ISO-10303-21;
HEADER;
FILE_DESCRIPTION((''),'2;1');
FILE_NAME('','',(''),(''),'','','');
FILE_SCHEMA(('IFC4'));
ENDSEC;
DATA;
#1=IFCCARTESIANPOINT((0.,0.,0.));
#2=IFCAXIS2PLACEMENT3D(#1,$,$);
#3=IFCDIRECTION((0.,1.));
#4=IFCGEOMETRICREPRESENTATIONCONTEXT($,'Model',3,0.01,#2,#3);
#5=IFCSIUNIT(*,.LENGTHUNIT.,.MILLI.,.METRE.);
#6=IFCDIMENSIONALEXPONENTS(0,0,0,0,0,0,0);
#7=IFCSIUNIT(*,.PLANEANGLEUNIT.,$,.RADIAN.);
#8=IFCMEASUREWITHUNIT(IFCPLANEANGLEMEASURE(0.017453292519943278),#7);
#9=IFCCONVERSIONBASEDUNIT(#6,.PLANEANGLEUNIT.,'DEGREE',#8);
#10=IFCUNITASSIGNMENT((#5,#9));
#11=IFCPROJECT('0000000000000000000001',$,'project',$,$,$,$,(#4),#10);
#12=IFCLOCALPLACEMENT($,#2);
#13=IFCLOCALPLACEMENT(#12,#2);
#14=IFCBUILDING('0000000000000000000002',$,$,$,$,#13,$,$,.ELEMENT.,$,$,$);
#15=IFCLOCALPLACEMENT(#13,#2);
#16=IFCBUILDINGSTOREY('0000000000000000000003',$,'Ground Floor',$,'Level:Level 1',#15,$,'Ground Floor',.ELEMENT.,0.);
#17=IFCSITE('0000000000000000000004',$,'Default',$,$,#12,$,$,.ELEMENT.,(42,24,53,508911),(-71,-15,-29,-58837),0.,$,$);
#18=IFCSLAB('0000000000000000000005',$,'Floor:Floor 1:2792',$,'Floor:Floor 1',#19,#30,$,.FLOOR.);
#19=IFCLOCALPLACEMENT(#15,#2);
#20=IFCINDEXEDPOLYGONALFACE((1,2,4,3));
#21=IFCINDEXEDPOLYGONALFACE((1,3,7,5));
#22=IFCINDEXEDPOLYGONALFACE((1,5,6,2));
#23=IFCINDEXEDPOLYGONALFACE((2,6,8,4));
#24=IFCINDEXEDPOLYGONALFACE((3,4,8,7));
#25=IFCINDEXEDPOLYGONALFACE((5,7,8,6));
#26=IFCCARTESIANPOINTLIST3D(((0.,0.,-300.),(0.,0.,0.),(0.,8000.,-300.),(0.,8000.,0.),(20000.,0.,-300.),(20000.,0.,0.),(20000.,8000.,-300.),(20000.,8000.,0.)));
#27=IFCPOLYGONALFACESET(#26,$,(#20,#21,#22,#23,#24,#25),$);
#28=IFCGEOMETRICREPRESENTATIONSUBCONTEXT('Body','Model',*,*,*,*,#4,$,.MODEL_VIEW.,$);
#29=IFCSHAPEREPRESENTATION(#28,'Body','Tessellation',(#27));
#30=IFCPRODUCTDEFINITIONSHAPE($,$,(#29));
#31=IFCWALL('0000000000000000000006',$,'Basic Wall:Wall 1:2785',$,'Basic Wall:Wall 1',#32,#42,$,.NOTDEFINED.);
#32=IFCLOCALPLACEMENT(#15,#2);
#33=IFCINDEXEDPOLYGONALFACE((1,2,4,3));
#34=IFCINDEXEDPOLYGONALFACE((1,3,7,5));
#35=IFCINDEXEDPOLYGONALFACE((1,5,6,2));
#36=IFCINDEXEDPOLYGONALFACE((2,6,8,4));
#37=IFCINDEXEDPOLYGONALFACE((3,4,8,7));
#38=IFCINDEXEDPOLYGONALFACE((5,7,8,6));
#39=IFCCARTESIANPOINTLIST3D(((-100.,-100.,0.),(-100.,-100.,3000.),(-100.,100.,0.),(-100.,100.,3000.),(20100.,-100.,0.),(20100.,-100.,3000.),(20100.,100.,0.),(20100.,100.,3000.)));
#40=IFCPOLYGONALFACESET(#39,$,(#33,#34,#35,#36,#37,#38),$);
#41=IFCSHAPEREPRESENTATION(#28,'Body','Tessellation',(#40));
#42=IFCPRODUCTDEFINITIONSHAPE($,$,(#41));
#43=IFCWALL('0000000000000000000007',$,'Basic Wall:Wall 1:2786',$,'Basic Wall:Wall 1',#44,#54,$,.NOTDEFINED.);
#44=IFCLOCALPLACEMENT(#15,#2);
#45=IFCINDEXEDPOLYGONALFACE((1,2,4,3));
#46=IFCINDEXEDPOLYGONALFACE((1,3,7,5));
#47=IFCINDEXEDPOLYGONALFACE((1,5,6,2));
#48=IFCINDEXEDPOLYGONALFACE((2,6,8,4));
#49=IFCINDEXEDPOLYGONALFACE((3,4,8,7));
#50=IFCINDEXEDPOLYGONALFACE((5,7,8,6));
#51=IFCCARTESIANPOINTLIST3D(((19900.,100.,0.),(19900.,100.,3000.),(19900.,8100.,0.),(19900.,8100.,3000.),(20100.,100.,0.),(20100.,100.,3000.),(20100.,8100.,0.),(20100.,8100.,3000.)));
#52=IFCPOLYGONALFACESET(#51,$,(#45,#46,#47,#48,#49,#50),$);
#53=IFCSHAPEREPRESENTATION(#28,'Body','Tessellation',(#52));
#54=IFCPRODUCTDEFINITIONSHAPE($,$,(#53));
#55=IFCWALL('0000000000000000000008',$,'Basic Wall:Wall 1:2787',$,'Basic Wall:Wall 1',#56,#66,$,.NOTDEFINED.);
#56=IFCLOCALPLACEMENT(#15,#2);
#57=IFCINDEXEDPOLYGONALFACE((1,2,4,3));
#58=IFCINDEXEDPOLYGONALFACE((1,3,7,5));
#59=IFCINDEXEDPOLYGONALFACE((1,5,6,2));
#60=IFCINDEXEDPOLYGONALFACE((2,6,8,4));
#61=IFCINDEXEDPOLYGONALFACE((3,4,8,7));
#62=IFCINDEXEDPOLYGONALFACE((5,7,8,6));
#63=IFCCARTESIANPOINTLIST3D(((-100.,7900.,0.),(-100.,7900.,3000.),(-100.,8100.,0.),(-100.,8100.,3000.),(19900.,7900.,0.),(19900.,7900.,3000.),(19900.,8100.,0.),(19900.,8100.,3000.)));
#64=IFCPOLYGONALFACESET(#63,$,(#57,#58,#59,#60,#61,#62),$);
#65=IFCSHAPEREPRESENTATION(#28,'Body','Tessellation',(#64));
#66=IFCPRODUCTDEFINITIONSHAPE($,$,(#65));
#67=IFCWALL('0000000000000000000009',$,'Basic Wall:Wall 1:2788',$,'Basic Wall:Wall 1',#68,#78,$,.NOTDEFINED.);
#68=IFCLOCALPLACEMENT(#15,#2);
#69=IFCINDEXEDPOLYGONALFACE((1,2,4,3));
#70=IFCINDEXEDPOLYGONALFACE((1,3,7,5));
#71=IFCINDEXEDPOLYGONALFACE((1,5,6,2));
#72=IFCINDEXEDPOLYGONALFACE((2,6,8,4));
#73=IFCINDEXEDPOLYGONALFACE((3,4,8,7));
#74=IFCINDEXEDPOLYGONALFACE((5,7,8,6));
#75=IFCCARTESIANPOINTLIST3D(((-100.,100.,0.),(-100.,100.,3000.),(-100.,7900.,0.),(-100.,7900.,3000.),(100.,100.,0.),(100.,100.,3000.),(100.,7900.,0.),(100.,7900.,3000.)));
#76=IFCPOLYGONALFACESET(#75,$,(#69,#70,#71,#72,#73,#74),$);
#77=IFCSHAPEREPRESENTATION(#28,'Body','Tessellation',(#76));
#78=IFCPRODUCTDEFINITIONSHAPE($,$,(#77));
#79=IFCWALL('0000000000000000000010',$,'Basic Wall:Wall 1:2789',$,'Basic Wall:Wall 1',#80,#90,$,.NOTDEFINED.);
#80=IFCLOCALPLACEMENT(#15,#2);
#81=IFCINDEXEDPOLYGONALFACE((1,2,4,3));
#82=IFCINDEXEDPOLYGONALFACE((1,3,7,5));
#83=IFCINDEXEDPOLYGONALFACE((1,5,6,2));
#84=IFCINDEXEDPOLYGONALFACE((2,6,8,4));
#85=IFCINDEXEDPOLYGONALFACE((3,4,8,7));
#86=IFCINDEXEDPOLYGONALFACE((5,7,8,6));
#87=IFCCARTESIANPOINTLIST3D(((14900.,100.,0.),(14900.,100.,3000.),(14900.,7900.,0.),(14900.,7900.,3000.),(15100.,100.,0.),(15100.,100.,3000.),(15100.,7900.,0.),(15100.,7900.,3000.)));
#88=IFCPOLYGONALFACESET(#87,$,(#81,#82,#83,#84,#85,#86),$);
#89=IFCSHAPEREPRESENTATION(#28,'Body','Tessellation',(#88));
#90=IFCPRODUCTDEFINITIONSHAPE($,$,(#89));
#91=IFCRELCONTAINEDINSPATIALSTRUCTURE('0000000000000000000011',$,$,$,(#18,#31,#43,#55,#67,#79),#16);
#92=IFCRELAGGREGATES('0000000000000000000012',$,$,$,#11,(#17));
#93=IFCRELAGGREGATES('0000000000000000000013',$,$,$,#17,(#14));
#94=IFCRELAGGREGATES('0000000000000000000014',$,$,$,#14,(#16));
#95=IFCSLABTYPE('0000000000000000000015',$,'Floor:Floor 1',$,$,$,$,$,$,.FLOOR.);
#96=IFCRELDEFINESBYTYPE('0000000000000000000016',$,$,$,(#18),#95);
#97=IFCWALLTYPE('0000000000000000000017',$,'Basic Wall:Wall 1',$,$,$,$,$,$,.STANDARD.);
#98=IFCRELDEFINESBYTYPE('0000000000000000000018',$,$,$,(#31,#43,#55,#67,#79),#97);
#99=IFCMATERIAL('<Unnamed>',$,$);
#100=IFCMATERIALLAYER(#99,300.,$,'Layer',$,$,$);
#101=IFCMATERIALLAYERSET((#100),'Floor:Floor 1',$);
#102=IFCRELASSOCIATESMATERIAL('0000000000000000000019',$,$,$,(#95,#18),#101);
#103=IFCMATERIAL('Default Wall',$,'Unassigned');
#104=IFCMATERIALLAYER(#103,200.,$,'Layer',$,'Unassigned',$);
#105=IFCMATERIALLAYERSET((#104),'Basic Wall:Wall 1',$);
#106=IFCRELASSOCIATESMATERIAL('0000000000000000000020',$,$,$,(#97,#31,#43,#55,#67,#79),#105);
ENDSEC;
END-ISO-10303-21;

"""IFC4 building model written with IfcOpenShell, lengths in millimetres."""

from ifc_helpers import new_model, entity, si_unit, converted_unit, direction, frame, frame_2d, origin, origin_2d_with_axis, place, context, subcontext, project, spatial, rectangle, extrude, material, layer, layer_set, layer_usage, type_object, element, save


model = new_model("IFC4")

# Units and contexts
model_context = context("Model", 3, precision=0.01, world=origin(), true_north=direction((0.0, 1.0)))
body_context = subcontext(model_context, "Body", "Model", "MODEL_VIEW")
ifc_project = project(units=[si_unit("LENGTHUNIT", "METRE", prefix="MILLI"), converted_unit("PLANEANGLEUNIT", "DEGREE", entity("IfcPlaneAngleMeasure", 0.017453292519943278), si_unit("PLANEANGLEUNIT", "RADIAN"), dimensions=[0, 0, 0, 0, 0, 0, 0])], contexts=[model_context])

# Site, building, storey
site_placement = place(None, origin())
site = spatial("IfcSite", under=ifc_project, at=site_placement, Name="Default", CompositionType="ELEMENT", RefLatitude=(42, 24, 53, 508911), RefLongitude=(-71, -15, -29, -58837), RefElevation=0.0)
building_placement = place(site_placement, origin())
building = spatial("IfcBuilding", under=site, at=building_placement, CompositionType="ELEMENT")
storey_placement = place(building_placement, origin())
storey = spatial("IfcBuildingStorey", under=building, at=storey_placement, Name="Ground Floor", ObjectType="Level:Level 1", LongName="Ground Floor", CompositionType="ELEMENT", Elevation=0.0)

# Slab
ifc_material_1 = material(Name="<Unnamed>")
ifc_layer_1 = layer(ifc_material_1, 300.0, Name="Layer")
ifc_layer_set_1 = layer_set([ifc_layer_1], Name="Floor:Floor 1")
ifc_layer_usage_1 = layer_usage(ifc_layer_set_1, "AXIS3", "POSITIVE", 0.0)
slab_type = type_object("IfcSlabType", Name="Floor:Floor 1", PredefinedType="FLOOR", material=ifc_layer_set_1)
slab_placement = place(storey_placement, origin())
element("IfcSlab", 1, at=slab_placement, inside=storey, type_object=slab_type, material=ifc_layer_usage_1, Name="Floor:Floor 1:2792", ObjectType="Floor:Floor 1", PredefinedType="FLOOR", context=body_context, shape_type="SweptSolid", body=[
    extrude(rectangle(XDim=8000.0, YDim=20000.0, at=origin_2d_with_axis()), frame((10000.0, 4000.0, 0.0), z_axis=(0.0, 0.0, -1.0), x_axis=(0.0, 1.0, 0.0)), (0.0, 0.0, 1.0), 300.0),
])

# Walls
ifc_material_2 = material(Name="Default Wall", Category="Unassigned")
ifc_layer_2 = layer(ifc_material_2, 200.0, Name="Layer", Category="Unassigned")
ifc_layer_set_2 = layer_set([ifc_layer_2], Name="Basic Wall:Wall 1")
ifc_layer_usage_2 = layer_usage(ifc_layer_set_2, "AXIS2", "NEGATIVE", 100.0)
wall_type = type_object("IfcWallType", Name="Basic Wall:Wall 1", PredefinedType="STANDARD", material=ifc_layer_set_2)
wall_1_placement = place(storey_placement, frame((-100.0, 0.0, 0.0)))
element("IfcWall", 2, at=wall_1_placement, inside=storey, type_object=wall_type, material=ifc_layer_usage_2, Name="Basic Wall:Wall 1:2785", ObjectType="Basic Wall:Wall 1", PredefinedType="NOTDEFINED", context=body_context, shape_type="SweptSolid", body=[
    extrude(rectangle(XDim=20200.0, YDim=200.0, at=frame_2d((10100.0, 0.0), x_axis=(-1.0, 0.0))), origin(), (0.0, 0.0, 1.0), 3000.0),
])
ifc_layer_usage_3 = layer_usage(ifc_layer_set_2, "AXIS2", "NEGATIVE", 100.0)
wall_2_placement = place(storey_placement, frame((20000.0, 100.0, 0.0), z_axis=(0.0, 0.0, 1.0), x_axis=(0.0, 1.0, 0.0)))
element("IfcWall", 3, at=wall_2_placement, inside=storey, type_object=wall_type, material=ifc_layer_usage_3, Name="Basic Wall:Wall 1:2786", ObjectType="Basic Wall:Wall 1", PredefinedType="NOTDEFINED", context=body_context, shape_type="SweptSolid", body=[
    extrude(rectangle(XDim=8000.0, YDim=200.0, at=frame_2d((4000.0, 0.0), x_axis=(-1.0, 0.0))), origin(), (0.0, 0.0, 1.0), 3000.0),
])
ifc_layer_usage_4 = layer_usage(ifc_layer_set_2, "AXIS2", "NEGATIVE", 100.0)
wall_3_placement = place(storey_placement, frame((19900.0, 8000.0, 0.0), z_axis=(0.0, 0.0, 1.0), x_axis=(-1.0, 0.0, 0.0)))
element("IfcWall", 4, at=wall_3_placement, inside=storey, type_object=wall_type, material=ifc_layer_usage_4, Name="Basic Wall:Wall 1:2787", ObjectType="Basic Wall:Wall 1", PredefinedType="NOTDEFINED", context=body_context, shape_type="SweptSolid", body=[
    extrude(rectangle(XDim=20000.0, YDim=200.0, at=frame_2d((10000.0, 0.0), x_axis=(-1.0, 0.0))), origin(), (0.0, 0.0, 1.0), 3000.0),
])
ifc_layer_usage_5 = layer_usage(ifc_layer_set_2, "AXIS2", "NEGATIVE", 100.0)
wall_4_placement = place(storey_placement, frame((0.0, 7900.0, 0.0), z_axis=(0.0, 0.0, 1.0), x_axis=(0.0, -1.0, 0.0)))
element("IfcWall", 5, at=wall_4_placement, inside=storey, type_object=wall_type, material=ifc_layer_usage_5, Name="Basic Wall:Wall 1:2788", ObjectType="Basic Wall:Wall 1", PredefinedType="NOTDEFINED", context=body_context, shape_type="SweptSolid", body=[
    extrude(rectangle(XDim=7800.0, YDim=200.0, at=frame_2d((3900.0, 0.0), x_axis=(-1.0, 0.0))), origin(), (0.0, 0.0, 1.0), 3000.0),
])
ifc_layer_usage_6 = layer_usage(ifc_layer_set_2, "AXIS2", "NEGATIVE", 100.0)
wall_5_placement = place(storey_placement, frame((15000.0, 100.0, 0.0), z_axis=(0.0, 0.0, 1.0), x_axis=(0.0, 1.0, 0.0)))
element("IfcWall", 6, at=wall_5_placement, inside=storey, type_object=wall_type, material=ifc_layer_usage_6, Name="Basic Wall:Wall 1:2789", ObjectType="Basic Wall:Wall 1", PredefinedType="NOTDEFINED", context=body_context, shape_type="SweptSolid", body=[
    extrude(rectangle(XDim=7800.0, YDim=200.0, at=frame_2d((3900.0, 0.0), x_axis=(-1.0, 0.0))), origin(), (0.0, 0.0, 1.0), 3000.0),
])

save(model, "model.ifc")
